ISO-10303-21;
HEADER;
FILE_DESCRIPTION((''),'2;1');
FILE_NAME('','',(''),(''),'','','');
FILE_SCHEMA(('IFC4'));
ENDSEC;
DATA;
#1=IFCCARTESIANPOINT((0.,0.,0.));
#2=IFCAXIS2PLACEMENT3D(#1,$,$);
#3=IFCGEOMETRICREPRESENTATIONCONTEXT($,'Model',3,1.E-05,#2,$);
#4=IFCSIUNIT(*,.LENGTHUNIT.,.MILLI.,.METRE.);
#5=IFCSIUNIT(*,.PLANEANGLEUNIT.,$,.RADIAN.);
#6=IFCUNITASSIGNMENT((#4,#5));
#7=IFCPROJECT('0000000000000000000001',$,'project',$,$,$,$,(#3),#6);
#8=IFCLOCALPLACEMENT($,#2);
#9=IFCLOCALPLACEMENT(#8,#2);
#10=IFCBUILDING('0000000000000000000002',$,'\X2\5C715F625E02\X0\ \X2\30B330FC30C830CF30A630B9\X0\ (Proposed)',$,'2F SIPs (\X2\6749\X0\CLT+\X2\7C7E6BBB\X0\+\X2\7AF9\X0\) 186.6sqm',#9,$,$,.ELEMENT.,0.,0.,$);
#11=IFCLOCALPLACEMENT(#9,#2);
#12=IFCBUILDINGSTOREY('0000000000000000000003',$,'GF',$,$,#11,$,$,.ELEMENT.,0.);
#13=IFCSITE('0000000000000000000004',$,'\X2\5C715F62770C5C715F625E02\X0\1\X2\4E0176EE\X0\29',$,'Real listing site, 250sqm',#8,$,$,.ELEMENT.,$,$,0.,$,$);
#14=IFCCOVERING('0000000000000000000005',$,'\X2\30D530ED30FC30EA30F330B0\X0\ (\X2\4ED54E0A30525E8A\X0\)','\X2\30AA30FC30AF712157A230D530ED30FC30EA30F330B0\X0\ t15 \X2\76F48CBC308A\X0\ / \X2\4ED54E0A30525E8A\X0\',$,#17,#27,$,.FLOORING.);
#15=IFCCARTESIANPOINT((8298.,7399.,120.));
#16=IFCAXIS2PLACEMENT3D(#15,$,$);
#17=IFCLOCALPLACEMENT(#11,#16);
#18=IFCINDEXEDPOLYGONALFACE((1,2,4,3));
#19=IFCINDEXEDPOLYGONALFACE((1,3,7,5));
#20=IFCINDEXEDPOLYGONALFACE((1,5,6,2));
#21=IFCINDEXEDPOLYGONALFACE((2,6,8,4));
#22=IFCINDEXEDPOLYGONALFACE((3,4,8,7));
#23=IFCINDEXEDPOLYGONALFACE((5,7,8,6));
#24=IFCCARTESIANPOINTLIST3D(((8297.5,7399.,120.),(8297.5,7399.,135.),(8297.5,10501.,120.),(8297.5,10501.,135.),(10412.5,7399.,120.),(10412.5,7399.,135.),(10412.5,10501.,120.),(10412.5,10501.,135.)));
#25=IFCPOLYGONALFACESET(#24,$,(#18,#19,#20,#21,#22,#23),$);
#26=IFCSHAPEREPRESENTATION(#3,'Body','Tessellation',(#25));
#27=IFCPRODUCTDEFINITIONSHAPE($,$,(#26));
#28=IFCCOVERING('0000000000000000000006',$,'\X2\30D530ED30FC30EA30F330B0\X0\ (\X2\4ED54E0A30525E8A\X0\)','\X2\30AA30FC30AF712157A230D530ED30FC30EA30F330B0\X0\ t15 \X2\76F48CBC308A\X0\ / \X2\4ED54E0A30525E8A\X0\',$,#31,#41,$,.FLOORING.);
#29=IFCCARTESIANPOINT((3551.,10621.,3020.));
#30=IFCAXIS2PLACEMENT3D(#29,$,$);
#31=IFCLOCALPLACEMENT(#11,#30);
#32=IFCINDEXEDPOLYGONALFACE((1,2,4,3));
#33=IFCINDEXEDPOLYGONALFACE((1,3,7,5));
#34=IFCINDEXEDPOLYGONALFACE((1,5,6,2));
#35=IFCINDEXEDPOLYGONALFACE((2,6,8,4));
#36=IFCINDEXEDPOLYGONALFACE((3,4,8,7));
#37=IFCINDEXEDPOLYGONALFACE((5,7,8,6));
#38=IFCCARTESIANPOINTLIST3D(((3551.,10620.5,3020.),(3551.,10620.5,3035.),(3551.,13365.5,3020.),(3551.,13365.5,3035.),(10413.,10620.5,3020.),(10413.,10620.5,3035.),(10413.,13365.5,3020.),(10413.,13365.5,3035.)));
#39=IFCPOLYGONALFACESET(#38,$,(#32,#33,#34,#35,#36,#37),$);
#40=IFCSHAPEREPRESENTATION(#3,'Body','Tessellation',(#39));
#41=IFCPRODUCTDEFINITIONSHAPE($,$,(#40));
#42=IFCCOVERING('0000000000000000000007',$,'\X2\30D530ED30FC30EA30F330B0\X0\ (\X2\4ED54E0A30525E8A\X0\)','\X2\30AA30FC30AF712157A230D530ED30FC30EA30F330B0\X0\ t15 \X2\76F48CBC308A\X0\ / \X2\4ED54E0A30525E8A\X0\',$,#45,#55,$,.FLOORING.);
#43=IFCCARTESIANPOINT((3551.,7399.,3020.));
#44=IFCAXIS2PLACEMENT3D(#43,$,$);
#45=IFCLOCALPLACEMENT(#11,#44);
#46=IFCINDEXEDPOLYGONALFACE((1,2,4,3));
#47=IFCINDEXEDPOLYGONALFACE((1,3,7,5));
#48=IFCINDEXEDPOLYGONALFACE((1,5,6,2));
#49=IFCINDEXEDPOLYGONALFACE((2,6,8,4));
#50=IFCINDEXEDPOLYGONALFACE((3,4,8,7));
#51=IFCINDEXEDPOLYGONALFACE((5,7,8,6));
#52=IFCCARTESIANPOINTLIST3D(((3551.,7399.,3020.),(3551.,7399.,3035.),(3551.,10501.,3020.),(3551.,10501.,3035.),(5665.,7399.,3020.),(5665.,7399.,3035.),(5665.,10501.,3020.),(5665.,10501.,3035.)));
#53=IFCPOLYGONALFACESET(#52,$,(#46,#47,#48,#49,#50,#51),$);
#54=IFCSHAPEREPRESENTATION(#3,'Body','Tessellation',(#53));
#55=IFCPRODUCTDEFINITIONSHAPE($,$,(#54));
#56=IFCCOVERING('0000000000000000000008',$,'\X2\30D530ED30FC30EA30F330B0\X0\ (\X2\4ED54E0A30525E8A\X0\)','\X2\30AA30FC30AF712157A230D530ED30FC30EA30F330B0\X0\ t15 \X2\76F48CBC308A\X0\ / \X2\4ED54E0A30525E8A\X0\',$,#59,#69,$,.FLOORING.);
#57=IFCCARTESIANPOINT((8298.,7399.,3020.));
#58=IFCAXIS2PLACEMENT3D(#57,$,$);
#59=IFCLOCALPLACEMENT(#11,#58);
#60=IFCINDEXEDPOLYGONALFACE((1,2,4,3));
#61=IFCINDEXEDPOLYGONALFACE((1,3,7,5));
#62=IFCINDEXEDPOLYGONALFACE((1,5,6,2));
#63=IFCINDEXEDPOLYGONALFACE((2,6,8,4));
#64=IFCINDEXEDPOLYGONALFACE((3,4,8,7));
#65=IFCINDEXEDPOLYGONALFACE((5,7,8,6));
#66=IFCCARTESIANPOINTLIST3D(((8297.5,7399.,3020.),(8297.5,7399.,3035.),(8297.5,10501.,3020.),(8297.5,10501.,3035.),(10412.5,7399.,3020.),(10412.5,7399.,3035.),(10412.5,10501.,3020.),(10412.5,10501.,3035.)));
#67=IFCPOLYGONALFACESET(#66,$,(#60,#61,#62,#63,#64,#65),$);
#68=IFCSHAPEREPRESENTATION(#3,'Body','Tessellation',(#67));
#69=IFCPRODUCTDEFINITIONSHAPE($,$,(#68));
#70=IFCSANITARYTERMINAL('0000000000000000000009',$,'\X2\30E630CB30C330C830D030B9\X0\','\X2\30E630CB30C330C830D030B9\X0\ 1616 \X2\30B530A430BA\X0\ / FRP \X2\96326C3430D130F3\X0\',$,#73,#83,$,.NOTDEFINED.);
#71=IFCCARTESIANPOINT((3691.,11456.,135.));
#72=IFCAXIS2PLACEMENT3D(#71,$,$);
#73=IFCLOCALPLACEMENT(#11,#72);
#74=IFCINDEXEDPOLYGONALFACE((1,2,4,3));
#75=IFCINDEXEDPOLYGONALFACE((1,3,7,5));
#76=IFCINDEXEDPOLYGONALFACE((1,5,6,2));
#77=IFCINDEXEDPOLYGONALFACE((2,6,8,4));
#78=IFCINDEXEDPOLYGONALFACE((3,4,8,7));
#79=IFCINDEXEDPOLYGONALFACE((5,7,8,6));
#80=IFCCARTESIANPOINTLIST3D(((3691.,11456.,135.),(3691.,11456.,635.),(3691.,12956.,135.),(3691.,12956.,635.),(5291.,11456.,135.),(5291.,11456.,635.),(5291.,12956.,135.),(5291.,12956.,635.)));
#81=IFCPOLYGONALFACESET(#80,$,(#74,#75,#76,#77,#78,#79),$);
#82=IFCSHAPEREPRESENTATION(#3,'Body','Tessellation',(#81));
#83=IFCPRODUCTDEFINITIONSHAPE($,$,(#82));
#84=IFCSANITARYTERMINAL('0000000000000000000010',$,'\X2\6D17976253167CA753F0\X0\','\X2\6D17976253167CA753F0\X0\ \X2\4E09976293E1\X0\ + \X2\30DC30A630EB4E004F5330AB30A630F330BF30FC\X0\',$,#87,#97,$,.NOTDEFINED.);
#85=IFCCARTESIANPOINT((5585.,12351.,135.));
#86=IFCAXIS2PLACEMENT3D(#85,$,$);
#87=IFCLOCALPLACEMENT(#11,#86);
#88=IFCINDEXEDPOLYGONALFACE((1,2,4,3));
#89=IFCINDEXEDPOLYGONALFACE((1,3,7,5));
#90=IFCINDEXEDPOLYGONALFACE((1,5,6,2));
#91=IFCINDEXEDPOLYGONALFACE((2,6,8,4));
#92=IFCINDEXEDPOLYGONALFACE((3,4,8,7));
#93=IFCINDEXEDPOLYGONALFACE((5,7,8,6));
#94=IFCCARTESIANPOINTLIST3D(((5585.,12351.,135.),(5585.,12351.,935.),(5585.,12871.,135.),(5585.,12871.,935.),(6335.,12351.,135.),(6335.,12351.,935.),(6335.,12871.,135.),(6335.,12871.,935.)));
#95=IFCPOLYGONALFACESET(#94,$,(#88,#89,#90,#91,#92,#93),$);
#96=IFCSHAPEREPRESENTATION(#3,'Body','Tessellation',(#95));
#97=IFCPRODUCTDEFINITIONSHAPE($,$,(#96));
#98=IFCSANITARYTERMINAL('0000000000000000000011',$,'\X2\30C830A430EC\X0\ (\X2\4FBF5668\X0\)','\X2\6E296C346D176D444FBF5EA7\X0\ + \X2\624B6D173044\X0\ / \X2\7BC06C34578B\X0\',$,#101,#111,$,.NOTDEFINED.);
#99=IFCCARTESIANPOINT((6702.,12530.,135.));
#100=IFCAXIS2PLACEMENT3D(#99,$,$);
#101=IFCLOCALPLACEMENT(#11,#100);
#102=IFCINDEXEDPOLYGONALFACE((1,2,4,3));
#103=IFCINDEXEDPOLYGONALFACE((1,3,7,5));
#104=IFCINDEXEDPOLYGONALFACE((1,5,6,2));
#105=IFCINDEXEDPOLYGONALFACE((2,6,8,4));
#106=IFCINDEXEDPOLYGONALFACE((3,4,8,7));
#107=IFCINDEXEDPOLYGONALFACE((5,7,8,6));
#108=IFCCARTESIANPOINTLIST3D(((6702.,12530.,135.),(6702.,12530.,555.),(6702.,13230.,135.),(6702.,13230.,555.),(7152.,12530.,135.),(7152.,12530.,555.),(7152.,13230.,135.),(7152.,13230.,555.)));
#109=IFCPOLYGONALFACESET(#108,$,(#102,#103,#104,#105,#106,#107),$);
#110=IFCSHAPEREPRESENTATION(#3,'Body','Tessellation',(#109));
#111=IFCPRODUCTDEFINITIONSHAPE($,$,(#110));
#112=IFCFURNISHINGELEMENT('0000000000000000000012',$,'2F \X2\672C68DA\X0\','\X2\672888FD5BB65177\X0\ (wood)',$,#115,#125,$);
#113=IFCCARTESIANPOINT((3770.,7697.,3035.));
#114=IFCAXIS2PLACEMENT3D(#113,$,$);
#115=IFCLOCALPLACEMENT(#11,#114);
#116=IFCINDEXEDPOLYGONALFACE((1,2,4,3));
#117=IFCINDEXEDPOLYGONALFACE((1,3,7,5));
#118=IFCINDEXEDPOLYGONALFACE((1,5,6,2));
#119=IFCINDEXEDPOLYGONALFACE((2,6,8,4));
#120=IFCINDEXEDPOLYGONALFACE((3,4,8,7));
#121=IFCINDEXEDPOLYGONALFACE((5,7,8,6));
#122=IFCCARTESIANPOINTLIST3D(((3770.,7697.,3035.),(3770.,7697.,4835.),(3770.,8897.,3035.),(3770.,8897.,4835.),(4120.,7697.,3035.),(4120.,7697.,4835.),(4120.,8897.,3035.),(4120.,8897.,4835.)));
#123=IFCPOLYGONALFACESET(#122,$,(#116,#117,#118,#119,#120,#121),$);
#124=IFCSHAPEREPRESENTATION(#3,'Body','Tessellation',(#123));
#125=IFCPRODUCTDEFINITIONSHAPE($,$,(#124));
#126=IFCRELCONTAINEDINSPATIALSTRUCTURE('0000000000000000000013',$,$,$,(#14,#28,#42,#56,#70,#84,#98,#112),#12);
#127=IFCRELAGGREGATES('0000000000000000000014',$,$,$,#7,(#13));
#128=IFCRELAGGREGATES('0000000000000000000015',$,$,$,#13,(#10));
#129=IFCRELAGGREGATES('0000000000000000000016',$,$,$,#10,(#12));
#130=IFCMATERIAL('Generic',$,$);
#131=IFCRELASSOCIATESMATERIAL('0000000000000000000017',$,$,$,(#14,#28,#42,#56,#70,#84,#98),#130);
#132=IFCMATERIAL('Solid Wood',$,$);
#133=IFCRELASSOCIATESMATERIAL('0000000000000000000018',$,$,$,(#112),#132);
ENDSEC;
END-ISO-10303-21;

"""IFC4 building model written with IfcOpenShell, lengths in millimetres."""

from ifc_helpers import new_model, si_unit, frame, frame_2d, origin, place, context, project, spatial, rectangle, extrude, material, element, save


model = new_model("IFC4")

# Units and contexts
model_context = context("Model", 3, precision=1e-05, world=origin())
ifc_project = project(units=[si_unit("LENGTHUNIT", "METRE", prefix="MILLI"), si_unit("PLANEANGLEUNIT", "RADIAN")], contexts=[model_context])

# Site, building, storey
site_placement = place(None, origin())
site = spatial("IfcSite", under=ifc_project, at=site_placement, Name="山形県山形市1丁目29", ObjectType="Real listing site, 250sqm", CompositionType="ELEMENT", RefElevation=0.0)
building_placement = place(site_placement, origin())
building = spatial("IfcBuilding", under=site, at=building_placement, Name="山形市 コートハウス (Proposed)", ObjectType="2F SIPs (杉CLT+籾殻+竹) 186.6sqm", CompositionType="ELEMENT", ElevationOfRefHeight=0.0, ElevationOfTerrain=0.0)
storey_placement = place(building_placement, origin())
storey = spatial("IfcBuildingStorey", under=building, at=storey_placement, Name="GF", CompositionType="ELEMENT", Elevation=0.0)

# Shared definitions
ifc_material_1 = material(Name="Solid Wood")
ifc_material_2 = material(Name="Generic")

# Coverings
covering_1_placement = place(storey_placement, frame((8298.0, 7399.0, 120.0)))
element("IfcCovering", 1, at=covering_1_placement, inside=storey, material=ifc_material_2, Name="フローリング (仕上げ床)", Description="オーク無垢フローリング t15 直貼り / 仕上げ床", PredefinedType="FLOORING", context=model_context, shape_type="SweptSolid", body=[
    extrude(rectangle(XDim=2115.0, YDim=3102.0, at=frame_2d((1057.0, 1551.0))), frame((8298.0, 7399.0, 120.0)), (0.0, 0.0, 1.0), 15.0),
])
covering_2_placement = place(storey_placement, frame((3551.0, 10621.0, 3020.0)))
element("IfcCovering", 2, at=covering_2_placement, inside=storey, material=ifc_material_2, Name="フローリング (仕上げ床)", Description="オーク無垢フローリング t15 直貼り / 仕上げ床", PredefinedType="FLOORING", context=model_context, shape_type="SweptSolid", body=[
    extrude(rectangle(XDim=6862.0, YDim=2745.0, at=frame_2d((3431.0, 1372.0))), frame((3551.0, 10621.0, 3020.0)), (0.0, 0.0, 1.0), 15.0),
])
covering_3_placement = place(storey_placement, frame((3551.0, 7399.0, 3020.0)))
element("IfcCovering", 3, at=covering_3_placement, inside=storey, material=ifc_material_2, Name="フローリング (仕上げ床)", Description="オーク無垢フローリング t15 直貼り / 仕上げ床", PredefinedType="FLOORING", context=model_context, shape_type="SweptSolid", body=[
    extrude(rectangle(XDim=2114.0, YDim=3102.0, at=frame_2d((1057.0, 1551.0))), frame((3551.0, 7399.0, 3020.0)), (0.0, 0.0, 1.0), 15.0),
])
covering_4_placement = place(storey_placement, frame((8298.0, 7399.0, 3020.0)))
element("IfcCovering", 4, at=covering_4_placement, inside=storey, material=ifc_material_2, Name="フローリング (仕上げ床)", Description="オーク無垢フローリング t15 直貼り / 仕上げ床", PredefinedType="FLOORING", context=model_context, shape_type="SweptSolid", body=[
    extrude(rectangle(XDim=2115.0, YDim=3102.0, at=frame_2d((1057.0, 1551.0))), frame((8298.0, 7399.0, 3020.0)), (0.0, 0.0, 1.0), 15.0),
])

# Sanitary terminals
sanitary_terminal_1_placement = place(storey_placement, frame((3691.0, 11456.0, 135.0)))
element("IfcSanitaryTerminal", 5, at=sanitary_terminal_1_placement, inside=storey, material=ifc_material_2, Name="ユニットバス", Description="ユニットバス 1616 サイズ / FRP 防水パン", PredefinedType="NOTDEFINED", context=model_context, shape_type="SweptSolid", body=[
    extrude(rectangle(XDim=1600.0, YDim=1500.0, at=frame_2d((800.0, 750.0))), frame((3691.0, 11456.0, 135.0)), (0.0, 0.0, 1.0), 500.0),
])
sanitary_terminal_2_placement = place(storey_placement, frame((5585.0, 12351.0, 135.0)))
element("IfcSanitaryTerminal", 6, at=sanitary_terminal_2_placement, inside=storey, material=ifc_material_2, Name="洗面化粧台", Description="洗面化粧台 三面鏡 + ボウル一体カウンター", PredefinedType="NOTDEFINED", context=model_context, shape_type="SweptSolid", body=[
    extrude(rectangle(XDim=750.0, YDim=520.0, at=frame_2d((375.0, 260.0))), frame((5585.0, 12351.0, 135.0)), (0.0, 0.0, 1.0), 800.0),
])
sanitary_terminal_3_placement = place(storey_placement, frame((6702.0, 12530.0, 135.0)))
element("IfcSanitaryTerminal", 7, at=sanitary_terminal_3_placement, inside=storey, material=ifc_material_2, Name="トイレ (便器)", Description="温水洗浄便座 + 手洗い / 節水型", PredefinedType="NOTDEFINED", context=model_context, shape_type="SweptSolid", body=[
    extrude(rectangle(XDim=450.0, YDim=700.0, at=frame_2d((225.0, 350.0))), frame((6702.0, 12530.0, 135.0)), (0.0, 0.0, 1.0), 420.0),
])

# Furnishing element
furnishing_placement = place(storey_placement, frame((3770.0, 7697.0, 3035.0)))
element("IfcFurnishingElement", 8, at=furnishing_placement, inside=storey, material=ifc_material_1, Name="2F 本棚", Description="木製家具 (wood)", context=model_context, shape_type="SweptSolid", body=[
    extrude(rectangle(XDim=350.0, YDim=1200.0, at=frame_2d((175.0, 600.0))), frame((3770.0, 7697.0, 3035.0)), (0.0, 0.0, 1.0), 1800.0),
])

save(model, "model.ifc")
